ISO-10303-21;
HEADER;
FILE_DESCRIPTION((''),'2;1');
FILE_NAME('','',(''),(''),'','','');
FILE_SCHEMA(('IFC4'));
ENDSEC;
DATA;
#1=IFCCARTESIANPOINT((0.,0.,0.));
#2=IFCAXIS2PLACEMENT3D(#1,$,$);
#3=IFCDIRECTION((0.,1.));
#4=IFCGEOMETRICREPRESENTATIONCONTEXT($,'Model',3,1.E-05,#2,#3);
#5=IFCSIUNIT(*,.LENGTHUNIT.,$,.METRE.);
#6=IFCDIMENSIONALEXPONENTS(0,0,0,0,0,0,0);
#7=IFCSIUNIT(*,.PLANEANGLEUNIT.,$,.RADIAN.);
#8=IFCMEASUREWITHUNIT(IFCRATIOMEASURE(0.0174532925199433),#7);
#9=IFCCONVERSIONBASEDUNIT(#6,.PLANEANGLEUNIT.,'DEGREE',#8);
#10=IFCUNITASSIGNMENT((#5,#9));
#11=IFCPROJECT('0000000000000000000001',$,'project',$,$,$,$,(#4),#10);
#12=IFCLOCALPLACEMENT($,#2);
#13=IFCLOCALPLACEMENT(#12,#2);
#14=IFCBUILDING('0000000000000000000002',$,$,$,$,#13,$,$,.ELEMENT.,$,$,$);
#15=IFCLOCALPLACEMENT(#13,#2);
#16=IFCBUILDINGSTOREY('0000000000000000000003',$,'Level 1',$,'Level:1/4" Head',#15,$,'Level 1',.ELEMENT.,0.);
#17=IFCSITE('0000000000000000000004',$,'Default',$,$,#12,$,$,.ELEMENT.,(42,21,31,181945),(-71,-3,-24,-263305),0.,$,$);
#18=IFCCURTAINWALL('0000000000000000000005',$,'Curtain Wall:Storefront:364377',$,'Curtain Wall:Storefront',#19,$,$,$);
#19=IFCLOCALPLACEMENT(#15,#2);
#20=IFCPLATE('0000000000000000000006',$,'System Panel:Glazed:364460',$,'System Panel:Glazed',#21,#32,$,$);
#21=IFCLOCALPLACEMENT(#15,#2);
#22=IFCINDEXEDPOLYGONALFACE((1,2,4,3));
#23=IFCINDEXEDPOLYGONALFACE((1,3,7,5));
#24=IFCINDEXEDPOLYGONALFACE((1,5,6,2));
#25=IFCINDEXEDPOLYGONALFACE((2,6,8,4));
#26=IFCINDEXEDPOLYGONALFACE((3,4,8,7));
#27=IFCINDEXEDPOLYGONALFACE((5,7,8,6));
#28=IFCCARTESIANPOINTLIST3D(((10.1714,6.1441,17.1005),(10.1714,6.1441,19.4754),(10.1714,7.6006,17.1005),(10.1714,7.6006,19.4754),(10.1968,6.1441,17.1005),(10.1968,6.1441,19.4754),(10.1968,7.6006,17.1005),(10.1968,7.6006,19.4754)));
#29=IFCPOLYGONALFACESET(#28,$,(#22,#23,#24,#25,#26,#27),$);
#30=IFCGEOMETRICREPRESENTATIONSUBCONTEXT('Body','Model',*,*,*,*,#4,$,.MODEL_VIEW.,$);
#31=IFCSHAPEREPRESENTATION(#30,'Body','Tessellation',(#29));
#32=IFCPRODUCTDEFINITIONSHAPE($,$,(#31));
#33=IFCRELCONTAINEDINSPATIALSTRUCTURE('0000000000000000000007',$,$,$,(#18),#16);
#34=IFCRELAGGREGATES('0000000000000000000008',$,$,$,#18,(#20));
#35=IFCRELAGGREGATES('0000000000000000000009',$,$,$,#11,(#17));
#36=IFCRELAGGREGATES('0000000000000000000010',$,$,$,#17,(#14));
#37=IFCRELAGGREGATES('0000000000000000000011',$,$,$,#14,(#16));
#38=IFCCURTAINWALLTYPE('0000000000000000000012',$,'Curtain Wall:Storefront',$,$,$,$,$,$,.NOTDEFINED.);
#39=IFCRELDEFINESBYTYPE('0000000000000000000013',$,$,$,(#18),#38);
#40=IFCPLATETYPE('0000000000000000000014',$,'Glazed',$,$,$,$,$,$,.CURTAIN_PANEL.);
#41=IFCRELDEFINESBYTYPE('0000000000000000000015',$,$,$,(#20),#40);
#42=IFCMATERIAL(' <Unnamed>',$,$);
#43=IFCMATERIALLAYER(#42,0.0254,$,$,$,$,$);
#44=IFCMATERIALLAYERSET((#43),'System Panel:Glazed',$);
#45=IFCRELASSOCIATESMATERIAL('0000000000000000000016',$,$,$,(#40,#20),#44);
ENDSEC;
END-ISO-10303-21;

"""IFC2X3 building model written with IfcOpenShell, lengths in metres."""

from ifc_helpers import new_model, entity, si_unit, converted_unit, direction, frame, origin, origin_2d_with_axis, place, context, subcontext, project, spatial, rectangle, extrude, source, transform, mapped, material, layer, layer_set, layer_usage, type_object, type_shapes, element, aggregate, save


model = new_model("IFC2X3")

# Units and contexts
model_context = context("Model", 3, precision=1e-05, world=origin(), true_north=direction((0.0, 1.0)))
body_context = subcontext(model_context, "Body", "Model", "MODEL_VIEW")
ifc_project = project(units=[si_unit("LENGTHUNIT", "METRE"), converted_unit("PLANEANGLEUNIT", "DEGREE", entity("IfcRatioMeasure", 0.0174532925199433), si_unit("PLANEANGLEUNIT", "RADIAN"), dimensions=[0, 0, 0, 0, 0, 0, 0])], contexts=[model_context])

# Site, building, storey
site_placement = place(None, origin())
site = spatial("IfcSite", under=ifc_project, at=site_placement, Name="Default", CompositionType="ELEMENT", RefLatitude=(42, 21, 31, 181945), RefLongitude=(-71, -3, -24, -263305), RefElevation=0.0)
building_placement = place(site_placement, origin())
building = spatial("IfcBuilding", under=site, at=building_placement, CompositionType="ELEMENT")
storey_placement = place(building_placement, origin())
storey = spatial("IfcBuildingStorey", under=building, at=storey_placement, Name="Level 1", ObjectType="Level:1/4\" Head", LongName="Level 1", CompositionType="ELEMENT", Elevation=0.0)

# Curtain wall, plate
curtain_wall_type = type_object("IfcCurtainWallType", Name="Curtain Wall:Storefront", PredefinedType="NOTDEFINED")
curtain_wall_placement = place(storey_placement, origin())
curtain_wall = element("IfcCurtainWall", 1, at=curtain_wall_placement, inside=storey, type_object=curtain_wall_type, Name="Curtain Wall:Storefront:364377", ObjectType="Curtain Wall:Storefront")
ifc_material_1 = material(Name=" <Unnamed>")
ifc_layer = layer(ifc_material_1, 0.0254)
ifc_layer_set = layer_set([ifc_layer], Name="System Panel:Glazed")
plate_type_1 = type_object("IfcPlateType", Name="Glazed", PredefinedType="CURTAIN_PANEL", material=ifc_layer_set)
shared_shape_1 = source(origin(), body_context, "Body", "SweptSolid", [
    extrude(rectangle(XDim=0.0254, YDim=1.4565, at=origin_2d_with_axis()), frame((0.7282, 0.0127, 0.0), z_axis=(0.0, 0.0, 1.0), x_axis=(0.0, 1.0, 0.0)), (0.0, 0.0, 1.0), 2.3749),
])
type_shapes(plate_type_1, [shared_shape_1])
ifc_layer_usage_1 = layer_usage(ifc_layer_set, "AXIS3", "POSITIVE", 0.1042)
plate_1_placement = place(curtain_wall_placement, frame((10.1968, 6.1441, 17.1005), z_axis=(0.0, 0.0, 1.0), x_axis=(0.0, 1.0, 0.0)))
plate_1 = element("IfcPlate", 2, at=plate_1_placement, type_object=plate_type_1, material=ifc_layer_usage_1, Name="System Panel:Glazed:364460", ObjectType="System Panel:Glazed", context=body_context, shape_type="MappedRepresentation", body=[
    mapped(shared_shape_1, transform((0.0, 0.0, 0.0), scale=1.0)),
])
aggregate(curtain_wall, [plate_1])

save(model, "model.ifc")
